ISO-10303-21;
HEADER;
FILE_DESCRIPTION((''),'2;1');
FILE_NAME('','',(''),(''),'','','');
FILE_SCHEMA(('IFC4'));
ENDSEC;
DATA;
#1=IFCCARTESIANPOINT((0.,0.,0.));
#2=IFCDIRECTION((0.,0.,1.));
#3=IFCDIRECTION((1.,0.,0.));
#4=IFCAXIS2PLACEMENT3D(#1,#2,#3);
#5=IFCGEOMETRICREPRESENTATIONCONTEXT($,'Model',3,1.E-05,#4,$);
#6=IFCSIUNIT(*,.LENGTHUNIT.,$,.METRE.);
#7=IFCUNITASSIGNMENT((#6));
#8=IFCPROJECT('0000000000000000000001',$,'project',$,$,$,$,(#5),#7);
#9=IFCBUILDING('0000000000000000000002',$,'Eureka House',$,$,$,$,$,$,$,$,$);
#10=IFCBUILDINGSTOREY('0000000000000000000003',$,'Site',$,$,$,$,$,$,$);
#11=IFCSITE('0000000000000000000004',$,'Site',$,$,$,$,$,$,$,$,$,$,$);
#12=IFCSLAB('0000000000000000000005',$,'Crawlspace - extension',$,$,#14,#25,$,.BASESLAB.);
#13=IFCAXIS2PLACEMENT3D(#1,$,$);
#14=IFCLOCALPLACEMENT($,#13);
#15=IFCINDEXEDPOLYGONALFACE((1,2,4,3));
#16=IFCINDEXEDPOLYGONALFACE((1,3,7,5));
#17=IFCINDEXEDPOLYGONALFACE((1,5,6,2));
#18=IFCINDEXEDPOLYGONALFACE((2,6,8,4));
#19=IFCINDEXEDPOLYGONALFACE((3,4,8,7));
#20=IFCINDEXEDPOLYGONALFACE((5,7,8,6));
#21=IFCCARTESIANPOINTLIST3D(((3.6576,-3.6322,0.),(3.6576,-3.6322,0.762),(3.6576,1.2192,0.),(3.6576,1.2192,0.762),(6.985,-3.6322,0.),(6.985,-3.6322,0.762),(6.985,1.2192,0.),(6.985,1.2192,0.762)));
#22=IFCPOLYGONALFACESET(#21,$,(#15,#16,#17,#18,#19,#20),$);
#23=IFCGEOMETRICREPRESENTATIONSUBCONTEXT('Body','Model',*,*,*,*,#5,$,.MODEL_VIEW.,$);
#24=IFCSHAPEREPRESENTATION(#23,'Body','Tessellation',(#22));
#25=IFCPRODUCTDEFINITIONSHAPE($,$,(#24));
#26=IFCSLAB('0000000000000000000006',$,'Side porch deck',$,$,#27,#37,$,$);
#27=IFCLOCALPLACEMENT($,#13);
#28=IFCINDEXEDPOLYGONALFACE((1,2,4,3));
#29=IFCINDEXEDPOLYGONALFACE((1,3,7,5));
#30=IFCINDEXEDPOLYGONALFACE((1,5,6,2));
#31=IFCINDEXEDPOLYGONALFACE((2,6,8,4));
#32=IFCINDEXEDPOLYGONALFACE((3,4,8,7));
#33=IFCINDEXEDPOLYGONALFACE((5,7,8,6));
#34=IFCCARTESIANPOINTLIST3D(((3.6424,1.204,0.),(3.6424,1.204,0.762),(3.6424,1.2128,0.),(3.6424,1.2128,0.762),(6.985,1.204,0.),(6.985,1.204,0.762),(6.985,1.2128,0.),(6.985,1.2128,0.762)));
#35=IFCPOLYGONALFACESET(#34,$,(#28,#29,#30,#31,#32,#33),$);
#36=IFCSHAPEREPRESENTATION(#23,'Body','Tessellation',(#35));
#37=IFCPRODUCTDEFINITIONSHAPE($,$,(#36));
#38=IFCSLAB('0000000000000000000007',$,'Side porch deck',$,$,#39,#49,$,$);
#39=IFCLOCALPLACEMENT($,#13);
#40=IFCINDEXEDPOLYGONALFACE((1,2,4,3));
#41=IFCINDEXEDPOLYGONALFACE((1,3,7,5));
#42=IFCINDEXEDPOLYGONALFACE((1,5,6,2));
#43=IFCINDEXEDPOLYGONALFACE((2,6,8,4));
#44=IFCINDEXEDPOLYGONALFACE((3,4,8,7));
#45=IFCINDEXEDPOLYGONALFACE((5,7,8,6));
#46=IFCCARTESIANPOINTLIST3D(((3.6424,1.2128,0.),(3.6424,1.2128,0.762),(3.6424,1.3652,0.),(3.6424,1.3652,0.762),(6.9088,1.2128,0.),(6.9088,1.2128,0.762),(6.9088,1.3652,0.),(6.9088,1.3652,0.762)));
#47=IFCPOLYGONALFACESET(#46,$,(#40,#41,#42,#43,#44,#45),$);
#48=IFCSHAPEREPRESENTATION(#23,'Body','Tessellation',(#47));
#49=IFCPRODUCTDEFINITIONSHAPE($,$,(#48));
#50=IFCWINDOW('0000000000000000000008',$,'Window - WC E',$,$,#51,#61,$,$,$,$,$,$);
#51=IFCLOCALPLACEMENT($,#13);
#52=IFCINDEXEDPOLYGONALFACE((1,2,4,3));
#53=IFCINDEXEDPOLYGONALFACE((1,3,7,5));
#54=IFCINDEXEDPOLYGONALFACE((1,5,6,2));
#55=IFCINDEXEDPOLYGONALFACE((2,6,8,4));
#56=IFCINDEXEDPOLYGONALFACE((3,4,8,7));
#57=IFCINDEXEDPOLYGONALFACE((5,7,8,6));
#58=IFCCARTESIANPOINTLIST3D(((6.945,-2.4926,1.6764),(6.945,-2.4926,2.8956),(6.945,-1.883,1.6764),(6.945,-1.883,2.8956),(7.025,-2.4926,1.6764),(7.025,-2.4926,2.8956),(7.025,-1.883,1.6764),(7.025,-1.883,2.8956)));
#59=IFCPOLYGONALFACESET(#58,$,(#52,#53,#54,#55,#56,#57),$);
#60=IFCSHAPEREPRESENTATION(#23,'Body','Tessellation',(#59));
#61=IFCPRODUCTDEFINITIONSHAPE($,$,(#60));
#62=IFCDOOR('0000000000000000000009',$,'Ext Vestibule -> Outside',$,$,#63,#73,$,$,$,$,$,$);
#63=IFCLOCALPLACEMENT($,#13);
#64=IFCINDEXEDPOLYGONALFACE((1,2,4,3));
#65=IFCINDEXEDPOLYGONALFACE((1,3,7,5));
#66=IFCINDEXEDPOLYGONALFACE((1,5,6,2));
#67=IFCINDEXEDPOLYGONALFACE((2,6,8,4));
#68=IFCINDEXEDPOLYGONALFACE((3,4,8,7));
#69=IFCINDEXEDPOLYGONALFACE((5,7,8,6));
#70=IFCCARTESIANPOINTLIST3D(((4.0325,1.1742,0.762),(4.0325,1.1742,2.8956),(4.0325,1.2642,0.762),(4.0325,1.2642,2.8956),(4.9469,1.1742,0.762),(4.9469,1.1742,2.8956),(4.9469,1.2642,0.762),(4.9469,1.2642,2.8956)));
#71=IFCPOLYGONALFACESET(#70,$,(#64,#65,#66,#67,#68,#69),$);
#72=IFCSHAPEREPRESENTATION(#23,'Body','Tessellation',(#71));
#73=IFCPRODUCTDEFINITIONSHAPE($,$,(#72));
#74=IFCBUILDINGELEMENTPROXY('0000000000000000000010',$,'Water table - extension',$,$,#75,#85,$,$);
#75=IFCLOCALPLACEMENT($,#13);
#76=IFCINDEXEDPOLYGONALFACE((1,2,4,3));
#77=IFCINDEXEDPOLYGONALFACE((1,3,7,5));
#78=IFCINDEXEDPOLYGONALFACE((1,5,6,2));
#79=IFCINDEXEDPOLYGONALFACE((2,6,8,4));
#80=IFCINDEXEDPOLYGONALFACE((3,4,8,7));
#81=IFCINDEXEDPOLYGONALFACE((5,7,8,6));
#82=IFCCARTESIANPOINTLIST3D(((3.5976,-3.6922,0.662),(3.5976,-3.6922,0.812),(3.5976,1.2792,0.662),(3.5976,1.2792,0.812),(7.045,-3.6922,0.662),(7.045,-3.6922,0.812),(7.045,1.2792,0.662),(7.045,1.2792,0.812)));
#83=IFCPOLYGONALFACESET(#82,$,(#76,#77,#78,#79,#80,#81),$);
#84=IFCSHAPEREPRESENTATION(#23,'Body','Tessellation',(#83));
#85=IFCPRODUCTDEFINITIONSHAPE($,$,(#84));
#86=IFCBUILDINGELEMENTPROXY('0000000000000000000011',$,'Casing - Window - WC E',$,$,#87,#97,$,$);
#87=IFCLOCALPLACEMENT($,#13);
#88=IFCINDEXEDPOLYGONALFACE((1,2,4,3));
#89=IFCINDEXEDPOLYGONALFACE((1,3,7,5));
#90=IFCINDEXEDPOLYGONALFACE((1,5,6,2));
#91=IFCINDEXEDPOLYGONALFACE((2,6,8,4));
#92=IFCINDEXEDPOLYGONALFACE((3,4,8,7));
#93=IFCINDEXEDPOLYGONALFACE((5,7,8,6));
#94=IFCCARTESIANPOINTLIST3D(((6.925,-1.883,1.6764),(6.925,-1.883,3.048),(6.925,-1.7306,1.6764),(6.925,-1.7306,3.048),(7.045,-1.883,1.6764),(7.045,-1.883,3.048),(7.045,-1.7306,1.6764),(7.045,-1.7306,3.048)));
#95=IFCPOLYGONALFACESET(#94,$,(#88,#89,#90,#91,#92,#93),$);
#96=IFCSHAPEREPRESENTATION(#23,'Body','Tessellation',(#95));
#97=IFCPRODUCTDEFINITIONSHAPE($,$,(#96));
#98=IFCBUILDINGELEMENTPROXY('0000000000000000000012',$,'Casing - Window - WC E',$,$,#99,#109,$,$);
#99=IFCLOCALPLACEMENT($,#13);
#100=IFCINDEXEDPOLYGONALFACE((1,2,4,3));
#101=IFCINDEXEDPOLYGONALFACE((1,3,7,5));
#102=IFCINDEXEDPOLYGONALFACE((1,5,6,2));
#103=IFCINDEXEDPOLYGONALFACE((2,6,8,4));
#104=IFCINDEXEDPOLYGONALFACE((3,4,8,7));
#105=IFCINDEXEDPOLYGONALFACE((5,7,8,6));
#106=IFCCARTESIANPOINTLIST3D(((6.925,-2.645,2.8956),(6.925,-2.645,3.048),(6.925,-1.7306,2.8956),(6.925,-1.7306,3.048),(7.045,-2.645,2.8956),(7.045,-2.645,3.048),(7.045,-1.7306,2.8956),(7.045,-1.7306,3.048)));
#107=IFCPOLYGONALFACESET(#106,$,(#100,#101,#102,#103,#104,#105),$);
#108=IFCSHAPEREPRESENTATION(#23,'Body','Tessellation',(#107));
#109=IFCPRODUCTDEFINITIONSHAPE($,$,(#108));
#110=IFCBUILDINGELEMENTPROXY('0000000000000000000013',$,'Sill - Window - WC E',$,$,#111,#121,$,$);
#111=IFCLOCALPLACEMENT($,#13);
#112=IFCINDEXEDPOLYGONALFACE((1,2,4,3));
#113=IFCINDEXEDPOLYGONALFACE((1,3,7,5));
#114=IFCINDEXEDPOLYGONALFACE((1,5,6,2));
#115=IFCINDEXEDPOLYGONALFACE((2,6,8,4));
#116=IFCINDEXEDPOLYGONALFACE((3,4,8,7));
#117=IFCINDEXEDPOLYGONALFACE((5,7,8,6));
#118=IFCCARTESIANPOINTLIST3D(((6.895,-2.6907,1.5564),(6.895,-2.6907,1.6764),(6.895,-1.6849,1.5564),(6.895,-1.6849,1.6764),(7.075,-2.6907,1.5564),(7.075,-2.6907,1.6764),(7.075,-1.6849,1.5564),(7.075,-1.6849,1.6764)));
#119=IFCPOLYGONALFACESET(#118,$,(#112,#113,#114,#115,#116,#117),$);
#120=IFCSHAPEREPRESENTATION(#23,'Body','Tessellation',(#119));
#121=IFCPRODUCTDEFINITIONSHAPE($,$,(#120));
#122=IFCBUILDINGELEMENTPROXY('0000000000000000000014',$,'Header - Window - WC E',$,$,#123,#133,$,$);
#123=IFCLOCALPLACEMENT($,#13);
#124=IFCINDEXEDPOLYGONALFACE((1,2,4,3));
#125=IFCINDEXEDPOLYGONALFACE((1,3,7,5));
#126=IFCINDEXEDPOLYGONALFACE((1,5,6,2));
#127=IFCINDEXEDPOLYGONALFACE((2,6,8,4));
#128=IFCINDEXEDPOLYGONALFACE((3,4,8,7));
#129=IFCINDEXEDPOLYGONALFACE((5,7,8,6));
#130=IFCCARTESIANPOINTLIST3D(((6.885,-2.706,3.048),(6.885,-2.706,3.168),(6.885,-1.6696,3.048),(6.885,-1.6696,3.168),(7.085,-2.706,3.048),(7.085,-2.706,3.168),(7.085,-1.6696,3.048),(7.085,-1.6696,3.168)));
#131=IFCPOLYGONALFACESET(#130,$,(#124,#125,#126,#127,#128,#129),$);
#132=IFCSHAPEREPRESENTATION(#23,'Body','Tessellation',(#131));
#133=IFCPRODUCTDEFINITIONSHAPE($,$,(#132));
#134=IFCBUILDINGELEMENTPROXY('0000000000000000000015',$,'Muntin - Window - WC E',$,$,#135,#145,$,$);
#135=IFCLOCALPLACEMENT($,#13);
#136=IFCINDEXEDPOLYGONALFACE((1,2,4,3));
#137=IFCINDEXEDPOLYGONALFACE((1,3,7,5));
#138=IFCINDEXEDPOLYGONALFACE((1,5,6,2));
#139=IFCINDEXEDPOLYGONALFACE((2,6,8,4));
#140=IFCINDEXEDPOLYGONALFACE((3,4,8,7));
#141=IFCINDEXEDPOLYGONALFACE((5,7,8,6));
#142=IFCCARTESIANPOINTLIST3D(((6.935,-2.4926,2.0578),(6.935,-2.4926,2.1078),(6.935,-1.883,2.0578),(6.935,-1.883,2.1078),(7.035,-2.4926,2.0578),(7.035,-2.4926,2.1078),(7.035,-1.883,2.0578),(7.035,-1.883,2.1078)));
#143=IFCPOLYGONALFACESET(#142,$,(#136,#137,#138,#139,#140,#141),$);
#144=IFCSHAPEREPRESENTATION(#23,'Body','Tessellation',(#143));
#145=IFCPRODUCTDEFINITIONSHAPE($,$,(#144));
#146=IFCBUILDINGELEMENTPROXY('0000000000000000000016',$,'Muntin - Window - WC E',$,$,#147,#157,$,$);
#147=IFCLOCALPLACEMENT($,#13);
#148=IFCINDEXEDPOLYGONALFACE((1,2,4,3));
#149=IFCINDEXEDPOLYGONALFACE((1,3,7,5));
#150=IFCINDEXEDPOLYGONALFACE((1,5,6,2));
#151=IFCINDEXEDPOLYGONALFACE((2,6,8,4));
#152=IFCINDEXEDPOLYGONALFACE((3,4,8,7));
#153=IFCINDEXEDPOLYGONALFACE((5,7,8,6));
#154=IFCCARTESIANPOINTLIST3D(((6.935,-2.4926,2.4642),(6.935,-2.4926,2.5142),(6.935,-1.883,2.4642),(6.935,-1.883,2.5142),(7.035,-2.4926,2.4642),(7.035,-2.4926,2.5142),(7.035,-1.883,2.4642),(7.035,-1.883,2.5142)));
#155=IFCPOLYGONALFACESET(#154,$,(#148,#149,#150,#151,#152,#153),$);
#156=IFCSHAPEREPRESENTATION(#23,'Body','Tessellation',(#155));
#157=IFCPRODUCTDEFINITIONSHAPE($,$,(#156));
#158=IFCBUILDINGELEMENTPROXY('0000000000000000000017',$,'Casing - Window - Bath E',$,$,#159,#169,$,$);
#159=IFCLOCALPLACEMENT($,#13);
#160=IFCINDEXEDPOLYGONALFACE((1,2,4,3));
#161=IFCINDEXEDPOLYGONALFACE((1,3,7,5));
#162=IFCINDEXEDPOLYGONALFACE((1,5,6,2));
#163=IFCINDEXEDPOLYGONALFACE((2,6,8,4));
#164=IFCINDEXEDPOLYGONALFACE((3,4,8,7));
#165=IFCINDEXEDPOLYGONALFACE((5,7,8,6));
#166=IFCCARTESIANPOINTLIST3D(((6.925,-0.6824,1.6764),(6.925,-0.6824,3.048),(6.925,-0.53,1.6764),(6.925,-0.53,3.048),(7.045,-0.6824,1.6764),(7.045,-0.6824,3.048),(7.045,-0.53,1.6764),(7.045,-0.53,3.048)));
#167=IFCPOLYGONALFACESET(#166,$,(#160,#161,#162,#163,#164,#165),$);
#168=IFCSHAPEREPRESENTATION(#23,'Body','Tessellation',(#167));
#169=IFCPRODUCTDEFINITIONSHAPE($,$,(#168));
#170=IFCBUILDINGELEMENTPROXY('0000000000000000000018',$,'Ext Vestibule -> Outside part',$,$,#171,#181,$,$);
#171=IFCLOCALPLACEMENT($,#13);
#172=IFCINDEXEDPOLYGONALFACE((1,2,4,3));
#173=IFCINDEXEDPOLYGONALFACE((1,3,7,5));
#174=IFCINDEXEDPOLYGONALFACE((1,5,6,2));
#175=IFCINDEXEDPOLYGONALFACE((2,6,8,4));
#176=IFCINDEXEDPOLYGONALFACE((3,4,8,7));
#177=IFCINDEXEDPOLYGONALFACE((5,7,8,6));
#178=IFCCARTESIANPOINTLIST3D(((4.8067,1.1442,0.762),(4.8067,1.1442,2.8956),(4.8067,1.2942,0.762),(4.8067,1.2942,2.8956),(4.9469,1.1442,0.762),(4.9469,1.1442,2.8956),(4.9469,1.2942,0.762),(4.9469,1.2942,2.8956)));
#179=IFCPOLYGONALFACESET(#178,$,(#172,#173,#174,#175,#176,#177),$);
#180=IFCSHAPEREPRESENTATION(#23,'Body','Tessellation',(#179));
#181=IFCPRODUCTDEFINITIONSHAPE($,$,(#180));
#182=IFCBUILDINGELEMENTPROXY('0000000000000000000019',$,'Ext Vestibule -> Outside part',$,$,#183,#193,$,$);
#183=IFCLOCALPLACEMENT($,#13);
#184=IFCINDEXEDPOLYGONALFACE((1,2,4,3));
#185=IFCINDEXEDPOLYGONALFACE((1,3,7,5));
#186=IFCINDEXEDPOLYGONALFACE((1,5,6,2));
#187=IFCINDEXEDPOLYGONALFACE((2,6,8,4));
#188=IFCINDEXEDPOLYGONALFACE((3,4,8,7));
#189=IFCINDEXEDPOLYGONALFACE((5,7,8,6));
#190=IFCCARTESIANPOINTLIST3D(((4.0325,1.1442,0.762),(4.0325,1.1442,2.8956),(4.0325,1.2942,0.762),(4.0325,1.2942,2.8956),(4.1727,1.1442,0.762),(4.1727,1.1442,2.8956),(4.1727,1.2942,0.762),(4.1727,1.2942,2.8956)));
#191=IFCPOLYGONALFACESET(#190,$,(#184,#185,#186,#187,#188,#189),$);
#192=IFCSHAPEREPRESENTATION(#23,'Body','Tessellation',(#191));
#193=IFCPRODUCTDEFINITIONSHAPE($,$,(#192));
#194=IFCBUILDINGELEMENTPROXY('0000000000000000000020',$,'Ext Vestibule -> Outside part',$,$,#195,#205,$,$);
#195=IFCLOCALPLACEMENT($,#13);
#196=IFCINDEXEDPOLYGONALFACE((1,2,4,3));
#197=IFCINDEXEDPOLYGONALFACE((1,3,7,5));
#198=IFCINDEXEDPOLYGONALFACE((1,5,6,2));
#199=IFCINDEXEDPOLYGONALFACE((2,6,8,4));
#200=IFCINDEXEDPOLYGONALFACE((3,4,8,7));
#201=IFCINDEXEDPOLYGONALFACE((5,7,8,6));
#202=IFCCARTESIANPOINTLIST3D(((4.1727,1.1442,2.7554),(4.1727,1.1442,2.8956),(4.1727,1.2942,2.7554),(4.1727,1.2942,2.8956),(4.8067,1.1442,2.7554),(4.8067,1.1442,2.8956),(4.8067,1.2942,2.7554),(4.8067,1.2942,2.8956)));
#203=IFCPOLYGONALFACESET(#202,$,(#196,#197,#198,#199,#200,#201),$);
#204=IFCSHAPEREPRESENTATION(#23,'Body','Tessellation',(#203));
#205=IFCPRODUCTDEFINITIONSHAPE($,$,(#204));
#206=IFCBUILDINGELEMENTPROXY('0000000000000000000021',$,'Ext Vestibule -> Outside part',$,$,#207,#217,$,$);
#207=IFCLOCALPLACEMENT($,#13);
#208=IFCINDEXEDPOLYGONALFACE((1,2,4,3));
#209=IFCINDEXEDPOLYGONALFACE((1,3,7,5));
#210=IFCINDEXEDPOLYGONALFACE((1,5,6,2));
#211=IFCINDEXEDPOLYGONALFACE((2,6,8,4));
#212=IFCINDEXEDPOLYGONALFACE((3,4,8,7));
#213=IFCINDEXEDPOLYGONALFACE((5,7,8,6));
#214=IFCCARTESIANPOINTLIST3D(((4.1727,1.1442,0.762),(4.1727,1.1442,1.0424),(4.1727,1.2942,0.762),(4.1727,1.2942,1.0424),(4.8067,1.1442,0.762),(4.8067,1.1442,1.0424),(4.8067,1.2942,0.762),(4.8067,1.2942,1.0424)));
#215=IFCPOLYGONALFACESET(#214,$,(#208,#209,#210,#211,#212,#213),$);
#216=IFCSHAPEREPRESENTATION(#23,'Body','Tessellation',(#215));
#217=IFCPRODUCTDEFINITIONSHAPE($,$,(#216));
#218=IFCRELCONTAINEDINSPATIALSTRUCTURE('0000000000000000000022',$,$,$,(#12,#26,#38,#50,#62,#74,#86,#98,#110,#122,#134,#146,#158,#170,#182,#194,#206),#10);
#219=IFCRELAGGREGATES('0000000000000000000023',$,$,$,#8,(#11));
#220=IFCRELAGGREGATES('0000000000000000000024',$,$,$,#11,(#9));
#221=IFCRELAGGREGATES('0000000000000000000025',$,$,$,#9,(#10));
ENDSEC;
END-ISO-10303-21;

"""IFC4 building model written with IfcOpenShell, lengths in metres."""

from ifc_helpers import new_model, si_unit, frame, origin, origin_with_axes, origin_2d, place, context, subcontext, project, spatial, rectangle, extrude, element, save


model = new_model("IFC4")

# Units and contexts
model_context = context("Model", 3, precision=1e-05, world=origin_with_axes())
body_context = subcontext(model_context, "Body", "Model", "MODEL_VIEW")
ifc_project = project(units=[si_unit("LENGTHUNIT", "METRE")], contexts=[model_context])

# Site, building, storey
site = spatial("IfcSite", under=ifc_project, Name="Site")
building = spatial("IfcBuilding", under=site, Name="Eureka House")
storey = spatial("IfcBuildingStorey", under=building, Name="Site")

# Slabs
slab_1_placement = place(None, frame((5.3213, -1.2065, 0.0), z_axis=(0.0, 0.0, 1.0), x_axis=(1.0, 0.0, 0.0)))
element("IfcSlab", 1, at=slab_1_placement, inside=storey, Name="Crawlspace - extension", PredefinedType="BASESLAB", context=body_context, shape_type="SweptSolid", body=[
    extrude(rectangle(XDim=3.3274, YDim=4.8514, at=origin_2d()), origin(), (0.0, 0.0, 1.0), 0.762),
])
slab_2_placement = place(None, frame((5.3137, 1.2084, 0.0), z_axis=(0.0, 0.0, 1.0), x_axis=(1.0, 0.0, 0.0)))
element("IfcSlab", 2, at=slab_2_placement, inside=storey, Name="Side porch deck", context=body_context, shape_type="SweptSolid", body=[
    extrude(rectangle(XDim=3.3427, YDim=0.0089, at=origin_2d()), origin(), (0.0, 0.0, 1.0), 0.762),
])
slab_3_placement = place(None, frame((5.2756, 1.289, 0.0), z_axis=(0.0, 0.0, 1.0), x_axis=(1.0, 0.0, 0.0)))
element("IfcSlab", 3, at=slab_3_placement, inside=storey, Name="Side porch deck", context=body_context, shape_type="SweptSolid", body=[
    extrude(rectangle(XDim=3.2665, YDim=0.1524, at=origin_2d()), origin(), (0.0, 0.0, 1.0), 0.762),
])

# Window
window_placement = place(None, frame((6.985, -2.1878, 1.6764), z_axis=(0.0, 0.0, 1.0), x_axis=(1.0, 0.0, 0.0)))
element("IfcWindow", 4, at=window_placement, inside=storey, Name="Window - WC E", context=body_context, shape_type="SweptSolid", body=[
    extrude(rectangle(XDim=0.08, YDim=0.6096, at=origin_2d()), origin(), (0.0, 0.0, 1.0), 1.2192),
])

# Door
door_placement = place(None, frame((4.4897, 1.2192, 0.762), z_axis=(0.0, 0.0, 1.0), x_axis=(1.0, 0.0, 0.0)))
element("IfcDoor", 5, at=door_placement, inside=storey, Name="Ext Vestibule -> Outside", context=body_context, shape_type="SweptSolid", body=[
    extrude(rectangle(XDim=0.9144, YDim=0.09, at=origin_2d()), origin(), (0.0, 0.0, 1.0), 2.1336),
])

# Building element proxies
proxy_1_placement = place(None, frame((5.3213, -1.2065, 0.662), z_axis=(0.0, 0.0, 1.0), x_axis=(1.0, 0.0, 0.0)))
element("IfcBuildingElementProxy", 6, at=proxy_1_placement, inside=storey, Name="Water table - extension", context=body_context, shape_type="SweptSolid", body=[
    extrude(rectangle(XDim=3.4474, YDim=4.9714, at=origin_2d()), origin(), (0.0, 0.0, 1.0), 0.15),
])
proxy_2_placement = place(None, frame((6.985, -1.8068, 1.6764), z_axis=(0.0, 0.0, 1.0), x_axis=(1.0, 0.0, 0.0)))
element("IfcBuildingElementProxy", 7, at=proxy_2_placement, inside=storey, Name="Casing - Window - WC E", context=body_context, shape_type="SweptSolid", body=[
    extrude(rectangle(XDim=0.12, YDim=0.1524, at=origin_2d()), origin(), (0.0, 0.0, 1.0), 1.3716),
])
proxy_3_placement = place(None, frame((6.985, -2.1878, 2.8956), z_axis=(0.0, 0.0, 1.0), x_axis=(1.0, 0.0, 0.0)))
element("IfcBuildingElementProxy", 8, at=proxy_3_placement, inside=storey, Name="Casing - Window - WC E", context=body_context, shape_type="SweptSolid", body=[
    extrude(rectangle(XDim=0.12, YDim=0.9144, at=origin_2d()), origin(), (0.0, 0.0, 1.0), 0.1524),
])
proxy_4_placement = place(None, frame((6.985, -2.1878, 1.5564), z_axis=(0.0, 0.0, 1.0), x_axis=(1.0, 0.0, 0.0)))
element("IfcBuildingElementProxy", 9, at=proxy_4_placement, inside=storey, Name="Sill - Window - WC E", context=body_context, shape_type="SweptSolid", body=[
    extrude(rectangle(XDim=0.18, YDim=1.0058, at=origin_2d()), origin(), (0.0, 0.0, 1.0), 0.12),
])
proxy_5_placement = place(None, frame((6.985, -2.1878, 3.048), z_axis=(0.0, 0.0, 1.0), x_axis=(1.0, 0.0, 0.0)))
element("IfcBuildingElementProxy", 10, at=proxy_5_placement, inside=storey, Name="Header - Window - WC E", context=body_context, shape_type="SweptSolid", body=[
    extrude(rectangle(XDim=0.2, YDim=1.0363, at=origin_2d()), origin(), (0.0, 0.0, 1.0), 0.12),
])
for number, where, z_axis, x_axis, name in (
    (11, (6.985, -2.1878, 2.0578), (0.0, 0.0, 1.0), (1.0, 0.0, 0.0), "Muntin - Window - WC E"),
    (12, (6.985, -2.1878, 2.4642), (0.0, 0.0, 1.0), (1.0, 0.0, 0.0), "Muntin - Window - WC E"),
):
    element("IfcBuildingElementProxy", number, at=place(None, frame(where, z_axis=z_axis, x_axis=x_axis)), inside=storey, Name=name, context=body_context, shape_type="SweptSolid", body=[
        extrude(rectangle(XDim=0.1, YDim=0.6096, at=origin_2d()), origin(), (0.0, 0.0, 1.0), 0.05),
    ])
proxy_6_placement = place(None, frame((6.985, -0.6062, 1.6764), z_axis=(0.0, 0.0, 1.0), x_axis=(1.0, 0.0, 0.0)))
element("IfcBuildingElementProxy", 13, at=proxy_6_placement, inside=storey, Name="Casing - Window - Bath E", context=body_context, shape_type="SweptSolid", body=[
    extrude(rectangle(XDim=0.12, YDim=0.1524, at=origin_2d()), origin(), (0.0, 0.0, 1.0), 1.3716),
])
for number, where, z_axis, x_axis, name in (
    (14, (4.8768, 1.2192, 0.762), (0.0, 0.0, 1.0), (1.0, 0.0, 0.0), "Ext Vestibule -> Outside part"),
    (15, (4.1026, 1.2192, 0.762), (0.0, 0.0, 1.0), (1.0, 0.0, 0.0), "Ext Vestibule -> Outside part"),
):
    element("IfcBuildingElementProxy", number, at=place(None, frame(where, z_axis=z_axis, x_axis=x_axis)), inside=storey, Name=name, context=body_context, shape_type="SweptSolid", body=[
        extrude(rectangle(XDim=0.1402, YDim=0.15, at=origin_2d()), origin(), (0.0, 0.0, 1.0), 2.1336),
    ])
proxy_7_placement = place(None, frame((4.4897, 1.2192, 2.7554), z_axis=(0.0, 0.0, 1.0), x_axis=(1.0, 0.0, 0.0)))
element("IfcBuildingElementProxy", 16, at=proxy_7_placement, inside=storey, Name="Ext Vestibule -> Outside part", context=body_context, shape_type="SweptSolid", body=[
    extrude(rectangle(XDim=0.634, YDim=0.15, at=origin_2d()), origin(), (0.0, 0.0, 1.0), 0.1402),
])
proxy_8_placement = place(None, frame((4.4897, 1.2192, 0.762), z_axis=(0.0, 0.0, 1.0), x_axis=(1.0, 0.0, 0.0)))
element("IfcBuildingElementProxy", 17, at=proxy_8_placement, inside=storey, Name="Ext Vestibule -> Outside part", context=body_context, shape_type="SweptSolid", body=[
    extrude(rectangle(XDim=0.634, YDim=0.15, at=origin_2d()), origin(), (0.0, 0.0, 1.0), 0.2804),
])

save(model, "model.ifc")
